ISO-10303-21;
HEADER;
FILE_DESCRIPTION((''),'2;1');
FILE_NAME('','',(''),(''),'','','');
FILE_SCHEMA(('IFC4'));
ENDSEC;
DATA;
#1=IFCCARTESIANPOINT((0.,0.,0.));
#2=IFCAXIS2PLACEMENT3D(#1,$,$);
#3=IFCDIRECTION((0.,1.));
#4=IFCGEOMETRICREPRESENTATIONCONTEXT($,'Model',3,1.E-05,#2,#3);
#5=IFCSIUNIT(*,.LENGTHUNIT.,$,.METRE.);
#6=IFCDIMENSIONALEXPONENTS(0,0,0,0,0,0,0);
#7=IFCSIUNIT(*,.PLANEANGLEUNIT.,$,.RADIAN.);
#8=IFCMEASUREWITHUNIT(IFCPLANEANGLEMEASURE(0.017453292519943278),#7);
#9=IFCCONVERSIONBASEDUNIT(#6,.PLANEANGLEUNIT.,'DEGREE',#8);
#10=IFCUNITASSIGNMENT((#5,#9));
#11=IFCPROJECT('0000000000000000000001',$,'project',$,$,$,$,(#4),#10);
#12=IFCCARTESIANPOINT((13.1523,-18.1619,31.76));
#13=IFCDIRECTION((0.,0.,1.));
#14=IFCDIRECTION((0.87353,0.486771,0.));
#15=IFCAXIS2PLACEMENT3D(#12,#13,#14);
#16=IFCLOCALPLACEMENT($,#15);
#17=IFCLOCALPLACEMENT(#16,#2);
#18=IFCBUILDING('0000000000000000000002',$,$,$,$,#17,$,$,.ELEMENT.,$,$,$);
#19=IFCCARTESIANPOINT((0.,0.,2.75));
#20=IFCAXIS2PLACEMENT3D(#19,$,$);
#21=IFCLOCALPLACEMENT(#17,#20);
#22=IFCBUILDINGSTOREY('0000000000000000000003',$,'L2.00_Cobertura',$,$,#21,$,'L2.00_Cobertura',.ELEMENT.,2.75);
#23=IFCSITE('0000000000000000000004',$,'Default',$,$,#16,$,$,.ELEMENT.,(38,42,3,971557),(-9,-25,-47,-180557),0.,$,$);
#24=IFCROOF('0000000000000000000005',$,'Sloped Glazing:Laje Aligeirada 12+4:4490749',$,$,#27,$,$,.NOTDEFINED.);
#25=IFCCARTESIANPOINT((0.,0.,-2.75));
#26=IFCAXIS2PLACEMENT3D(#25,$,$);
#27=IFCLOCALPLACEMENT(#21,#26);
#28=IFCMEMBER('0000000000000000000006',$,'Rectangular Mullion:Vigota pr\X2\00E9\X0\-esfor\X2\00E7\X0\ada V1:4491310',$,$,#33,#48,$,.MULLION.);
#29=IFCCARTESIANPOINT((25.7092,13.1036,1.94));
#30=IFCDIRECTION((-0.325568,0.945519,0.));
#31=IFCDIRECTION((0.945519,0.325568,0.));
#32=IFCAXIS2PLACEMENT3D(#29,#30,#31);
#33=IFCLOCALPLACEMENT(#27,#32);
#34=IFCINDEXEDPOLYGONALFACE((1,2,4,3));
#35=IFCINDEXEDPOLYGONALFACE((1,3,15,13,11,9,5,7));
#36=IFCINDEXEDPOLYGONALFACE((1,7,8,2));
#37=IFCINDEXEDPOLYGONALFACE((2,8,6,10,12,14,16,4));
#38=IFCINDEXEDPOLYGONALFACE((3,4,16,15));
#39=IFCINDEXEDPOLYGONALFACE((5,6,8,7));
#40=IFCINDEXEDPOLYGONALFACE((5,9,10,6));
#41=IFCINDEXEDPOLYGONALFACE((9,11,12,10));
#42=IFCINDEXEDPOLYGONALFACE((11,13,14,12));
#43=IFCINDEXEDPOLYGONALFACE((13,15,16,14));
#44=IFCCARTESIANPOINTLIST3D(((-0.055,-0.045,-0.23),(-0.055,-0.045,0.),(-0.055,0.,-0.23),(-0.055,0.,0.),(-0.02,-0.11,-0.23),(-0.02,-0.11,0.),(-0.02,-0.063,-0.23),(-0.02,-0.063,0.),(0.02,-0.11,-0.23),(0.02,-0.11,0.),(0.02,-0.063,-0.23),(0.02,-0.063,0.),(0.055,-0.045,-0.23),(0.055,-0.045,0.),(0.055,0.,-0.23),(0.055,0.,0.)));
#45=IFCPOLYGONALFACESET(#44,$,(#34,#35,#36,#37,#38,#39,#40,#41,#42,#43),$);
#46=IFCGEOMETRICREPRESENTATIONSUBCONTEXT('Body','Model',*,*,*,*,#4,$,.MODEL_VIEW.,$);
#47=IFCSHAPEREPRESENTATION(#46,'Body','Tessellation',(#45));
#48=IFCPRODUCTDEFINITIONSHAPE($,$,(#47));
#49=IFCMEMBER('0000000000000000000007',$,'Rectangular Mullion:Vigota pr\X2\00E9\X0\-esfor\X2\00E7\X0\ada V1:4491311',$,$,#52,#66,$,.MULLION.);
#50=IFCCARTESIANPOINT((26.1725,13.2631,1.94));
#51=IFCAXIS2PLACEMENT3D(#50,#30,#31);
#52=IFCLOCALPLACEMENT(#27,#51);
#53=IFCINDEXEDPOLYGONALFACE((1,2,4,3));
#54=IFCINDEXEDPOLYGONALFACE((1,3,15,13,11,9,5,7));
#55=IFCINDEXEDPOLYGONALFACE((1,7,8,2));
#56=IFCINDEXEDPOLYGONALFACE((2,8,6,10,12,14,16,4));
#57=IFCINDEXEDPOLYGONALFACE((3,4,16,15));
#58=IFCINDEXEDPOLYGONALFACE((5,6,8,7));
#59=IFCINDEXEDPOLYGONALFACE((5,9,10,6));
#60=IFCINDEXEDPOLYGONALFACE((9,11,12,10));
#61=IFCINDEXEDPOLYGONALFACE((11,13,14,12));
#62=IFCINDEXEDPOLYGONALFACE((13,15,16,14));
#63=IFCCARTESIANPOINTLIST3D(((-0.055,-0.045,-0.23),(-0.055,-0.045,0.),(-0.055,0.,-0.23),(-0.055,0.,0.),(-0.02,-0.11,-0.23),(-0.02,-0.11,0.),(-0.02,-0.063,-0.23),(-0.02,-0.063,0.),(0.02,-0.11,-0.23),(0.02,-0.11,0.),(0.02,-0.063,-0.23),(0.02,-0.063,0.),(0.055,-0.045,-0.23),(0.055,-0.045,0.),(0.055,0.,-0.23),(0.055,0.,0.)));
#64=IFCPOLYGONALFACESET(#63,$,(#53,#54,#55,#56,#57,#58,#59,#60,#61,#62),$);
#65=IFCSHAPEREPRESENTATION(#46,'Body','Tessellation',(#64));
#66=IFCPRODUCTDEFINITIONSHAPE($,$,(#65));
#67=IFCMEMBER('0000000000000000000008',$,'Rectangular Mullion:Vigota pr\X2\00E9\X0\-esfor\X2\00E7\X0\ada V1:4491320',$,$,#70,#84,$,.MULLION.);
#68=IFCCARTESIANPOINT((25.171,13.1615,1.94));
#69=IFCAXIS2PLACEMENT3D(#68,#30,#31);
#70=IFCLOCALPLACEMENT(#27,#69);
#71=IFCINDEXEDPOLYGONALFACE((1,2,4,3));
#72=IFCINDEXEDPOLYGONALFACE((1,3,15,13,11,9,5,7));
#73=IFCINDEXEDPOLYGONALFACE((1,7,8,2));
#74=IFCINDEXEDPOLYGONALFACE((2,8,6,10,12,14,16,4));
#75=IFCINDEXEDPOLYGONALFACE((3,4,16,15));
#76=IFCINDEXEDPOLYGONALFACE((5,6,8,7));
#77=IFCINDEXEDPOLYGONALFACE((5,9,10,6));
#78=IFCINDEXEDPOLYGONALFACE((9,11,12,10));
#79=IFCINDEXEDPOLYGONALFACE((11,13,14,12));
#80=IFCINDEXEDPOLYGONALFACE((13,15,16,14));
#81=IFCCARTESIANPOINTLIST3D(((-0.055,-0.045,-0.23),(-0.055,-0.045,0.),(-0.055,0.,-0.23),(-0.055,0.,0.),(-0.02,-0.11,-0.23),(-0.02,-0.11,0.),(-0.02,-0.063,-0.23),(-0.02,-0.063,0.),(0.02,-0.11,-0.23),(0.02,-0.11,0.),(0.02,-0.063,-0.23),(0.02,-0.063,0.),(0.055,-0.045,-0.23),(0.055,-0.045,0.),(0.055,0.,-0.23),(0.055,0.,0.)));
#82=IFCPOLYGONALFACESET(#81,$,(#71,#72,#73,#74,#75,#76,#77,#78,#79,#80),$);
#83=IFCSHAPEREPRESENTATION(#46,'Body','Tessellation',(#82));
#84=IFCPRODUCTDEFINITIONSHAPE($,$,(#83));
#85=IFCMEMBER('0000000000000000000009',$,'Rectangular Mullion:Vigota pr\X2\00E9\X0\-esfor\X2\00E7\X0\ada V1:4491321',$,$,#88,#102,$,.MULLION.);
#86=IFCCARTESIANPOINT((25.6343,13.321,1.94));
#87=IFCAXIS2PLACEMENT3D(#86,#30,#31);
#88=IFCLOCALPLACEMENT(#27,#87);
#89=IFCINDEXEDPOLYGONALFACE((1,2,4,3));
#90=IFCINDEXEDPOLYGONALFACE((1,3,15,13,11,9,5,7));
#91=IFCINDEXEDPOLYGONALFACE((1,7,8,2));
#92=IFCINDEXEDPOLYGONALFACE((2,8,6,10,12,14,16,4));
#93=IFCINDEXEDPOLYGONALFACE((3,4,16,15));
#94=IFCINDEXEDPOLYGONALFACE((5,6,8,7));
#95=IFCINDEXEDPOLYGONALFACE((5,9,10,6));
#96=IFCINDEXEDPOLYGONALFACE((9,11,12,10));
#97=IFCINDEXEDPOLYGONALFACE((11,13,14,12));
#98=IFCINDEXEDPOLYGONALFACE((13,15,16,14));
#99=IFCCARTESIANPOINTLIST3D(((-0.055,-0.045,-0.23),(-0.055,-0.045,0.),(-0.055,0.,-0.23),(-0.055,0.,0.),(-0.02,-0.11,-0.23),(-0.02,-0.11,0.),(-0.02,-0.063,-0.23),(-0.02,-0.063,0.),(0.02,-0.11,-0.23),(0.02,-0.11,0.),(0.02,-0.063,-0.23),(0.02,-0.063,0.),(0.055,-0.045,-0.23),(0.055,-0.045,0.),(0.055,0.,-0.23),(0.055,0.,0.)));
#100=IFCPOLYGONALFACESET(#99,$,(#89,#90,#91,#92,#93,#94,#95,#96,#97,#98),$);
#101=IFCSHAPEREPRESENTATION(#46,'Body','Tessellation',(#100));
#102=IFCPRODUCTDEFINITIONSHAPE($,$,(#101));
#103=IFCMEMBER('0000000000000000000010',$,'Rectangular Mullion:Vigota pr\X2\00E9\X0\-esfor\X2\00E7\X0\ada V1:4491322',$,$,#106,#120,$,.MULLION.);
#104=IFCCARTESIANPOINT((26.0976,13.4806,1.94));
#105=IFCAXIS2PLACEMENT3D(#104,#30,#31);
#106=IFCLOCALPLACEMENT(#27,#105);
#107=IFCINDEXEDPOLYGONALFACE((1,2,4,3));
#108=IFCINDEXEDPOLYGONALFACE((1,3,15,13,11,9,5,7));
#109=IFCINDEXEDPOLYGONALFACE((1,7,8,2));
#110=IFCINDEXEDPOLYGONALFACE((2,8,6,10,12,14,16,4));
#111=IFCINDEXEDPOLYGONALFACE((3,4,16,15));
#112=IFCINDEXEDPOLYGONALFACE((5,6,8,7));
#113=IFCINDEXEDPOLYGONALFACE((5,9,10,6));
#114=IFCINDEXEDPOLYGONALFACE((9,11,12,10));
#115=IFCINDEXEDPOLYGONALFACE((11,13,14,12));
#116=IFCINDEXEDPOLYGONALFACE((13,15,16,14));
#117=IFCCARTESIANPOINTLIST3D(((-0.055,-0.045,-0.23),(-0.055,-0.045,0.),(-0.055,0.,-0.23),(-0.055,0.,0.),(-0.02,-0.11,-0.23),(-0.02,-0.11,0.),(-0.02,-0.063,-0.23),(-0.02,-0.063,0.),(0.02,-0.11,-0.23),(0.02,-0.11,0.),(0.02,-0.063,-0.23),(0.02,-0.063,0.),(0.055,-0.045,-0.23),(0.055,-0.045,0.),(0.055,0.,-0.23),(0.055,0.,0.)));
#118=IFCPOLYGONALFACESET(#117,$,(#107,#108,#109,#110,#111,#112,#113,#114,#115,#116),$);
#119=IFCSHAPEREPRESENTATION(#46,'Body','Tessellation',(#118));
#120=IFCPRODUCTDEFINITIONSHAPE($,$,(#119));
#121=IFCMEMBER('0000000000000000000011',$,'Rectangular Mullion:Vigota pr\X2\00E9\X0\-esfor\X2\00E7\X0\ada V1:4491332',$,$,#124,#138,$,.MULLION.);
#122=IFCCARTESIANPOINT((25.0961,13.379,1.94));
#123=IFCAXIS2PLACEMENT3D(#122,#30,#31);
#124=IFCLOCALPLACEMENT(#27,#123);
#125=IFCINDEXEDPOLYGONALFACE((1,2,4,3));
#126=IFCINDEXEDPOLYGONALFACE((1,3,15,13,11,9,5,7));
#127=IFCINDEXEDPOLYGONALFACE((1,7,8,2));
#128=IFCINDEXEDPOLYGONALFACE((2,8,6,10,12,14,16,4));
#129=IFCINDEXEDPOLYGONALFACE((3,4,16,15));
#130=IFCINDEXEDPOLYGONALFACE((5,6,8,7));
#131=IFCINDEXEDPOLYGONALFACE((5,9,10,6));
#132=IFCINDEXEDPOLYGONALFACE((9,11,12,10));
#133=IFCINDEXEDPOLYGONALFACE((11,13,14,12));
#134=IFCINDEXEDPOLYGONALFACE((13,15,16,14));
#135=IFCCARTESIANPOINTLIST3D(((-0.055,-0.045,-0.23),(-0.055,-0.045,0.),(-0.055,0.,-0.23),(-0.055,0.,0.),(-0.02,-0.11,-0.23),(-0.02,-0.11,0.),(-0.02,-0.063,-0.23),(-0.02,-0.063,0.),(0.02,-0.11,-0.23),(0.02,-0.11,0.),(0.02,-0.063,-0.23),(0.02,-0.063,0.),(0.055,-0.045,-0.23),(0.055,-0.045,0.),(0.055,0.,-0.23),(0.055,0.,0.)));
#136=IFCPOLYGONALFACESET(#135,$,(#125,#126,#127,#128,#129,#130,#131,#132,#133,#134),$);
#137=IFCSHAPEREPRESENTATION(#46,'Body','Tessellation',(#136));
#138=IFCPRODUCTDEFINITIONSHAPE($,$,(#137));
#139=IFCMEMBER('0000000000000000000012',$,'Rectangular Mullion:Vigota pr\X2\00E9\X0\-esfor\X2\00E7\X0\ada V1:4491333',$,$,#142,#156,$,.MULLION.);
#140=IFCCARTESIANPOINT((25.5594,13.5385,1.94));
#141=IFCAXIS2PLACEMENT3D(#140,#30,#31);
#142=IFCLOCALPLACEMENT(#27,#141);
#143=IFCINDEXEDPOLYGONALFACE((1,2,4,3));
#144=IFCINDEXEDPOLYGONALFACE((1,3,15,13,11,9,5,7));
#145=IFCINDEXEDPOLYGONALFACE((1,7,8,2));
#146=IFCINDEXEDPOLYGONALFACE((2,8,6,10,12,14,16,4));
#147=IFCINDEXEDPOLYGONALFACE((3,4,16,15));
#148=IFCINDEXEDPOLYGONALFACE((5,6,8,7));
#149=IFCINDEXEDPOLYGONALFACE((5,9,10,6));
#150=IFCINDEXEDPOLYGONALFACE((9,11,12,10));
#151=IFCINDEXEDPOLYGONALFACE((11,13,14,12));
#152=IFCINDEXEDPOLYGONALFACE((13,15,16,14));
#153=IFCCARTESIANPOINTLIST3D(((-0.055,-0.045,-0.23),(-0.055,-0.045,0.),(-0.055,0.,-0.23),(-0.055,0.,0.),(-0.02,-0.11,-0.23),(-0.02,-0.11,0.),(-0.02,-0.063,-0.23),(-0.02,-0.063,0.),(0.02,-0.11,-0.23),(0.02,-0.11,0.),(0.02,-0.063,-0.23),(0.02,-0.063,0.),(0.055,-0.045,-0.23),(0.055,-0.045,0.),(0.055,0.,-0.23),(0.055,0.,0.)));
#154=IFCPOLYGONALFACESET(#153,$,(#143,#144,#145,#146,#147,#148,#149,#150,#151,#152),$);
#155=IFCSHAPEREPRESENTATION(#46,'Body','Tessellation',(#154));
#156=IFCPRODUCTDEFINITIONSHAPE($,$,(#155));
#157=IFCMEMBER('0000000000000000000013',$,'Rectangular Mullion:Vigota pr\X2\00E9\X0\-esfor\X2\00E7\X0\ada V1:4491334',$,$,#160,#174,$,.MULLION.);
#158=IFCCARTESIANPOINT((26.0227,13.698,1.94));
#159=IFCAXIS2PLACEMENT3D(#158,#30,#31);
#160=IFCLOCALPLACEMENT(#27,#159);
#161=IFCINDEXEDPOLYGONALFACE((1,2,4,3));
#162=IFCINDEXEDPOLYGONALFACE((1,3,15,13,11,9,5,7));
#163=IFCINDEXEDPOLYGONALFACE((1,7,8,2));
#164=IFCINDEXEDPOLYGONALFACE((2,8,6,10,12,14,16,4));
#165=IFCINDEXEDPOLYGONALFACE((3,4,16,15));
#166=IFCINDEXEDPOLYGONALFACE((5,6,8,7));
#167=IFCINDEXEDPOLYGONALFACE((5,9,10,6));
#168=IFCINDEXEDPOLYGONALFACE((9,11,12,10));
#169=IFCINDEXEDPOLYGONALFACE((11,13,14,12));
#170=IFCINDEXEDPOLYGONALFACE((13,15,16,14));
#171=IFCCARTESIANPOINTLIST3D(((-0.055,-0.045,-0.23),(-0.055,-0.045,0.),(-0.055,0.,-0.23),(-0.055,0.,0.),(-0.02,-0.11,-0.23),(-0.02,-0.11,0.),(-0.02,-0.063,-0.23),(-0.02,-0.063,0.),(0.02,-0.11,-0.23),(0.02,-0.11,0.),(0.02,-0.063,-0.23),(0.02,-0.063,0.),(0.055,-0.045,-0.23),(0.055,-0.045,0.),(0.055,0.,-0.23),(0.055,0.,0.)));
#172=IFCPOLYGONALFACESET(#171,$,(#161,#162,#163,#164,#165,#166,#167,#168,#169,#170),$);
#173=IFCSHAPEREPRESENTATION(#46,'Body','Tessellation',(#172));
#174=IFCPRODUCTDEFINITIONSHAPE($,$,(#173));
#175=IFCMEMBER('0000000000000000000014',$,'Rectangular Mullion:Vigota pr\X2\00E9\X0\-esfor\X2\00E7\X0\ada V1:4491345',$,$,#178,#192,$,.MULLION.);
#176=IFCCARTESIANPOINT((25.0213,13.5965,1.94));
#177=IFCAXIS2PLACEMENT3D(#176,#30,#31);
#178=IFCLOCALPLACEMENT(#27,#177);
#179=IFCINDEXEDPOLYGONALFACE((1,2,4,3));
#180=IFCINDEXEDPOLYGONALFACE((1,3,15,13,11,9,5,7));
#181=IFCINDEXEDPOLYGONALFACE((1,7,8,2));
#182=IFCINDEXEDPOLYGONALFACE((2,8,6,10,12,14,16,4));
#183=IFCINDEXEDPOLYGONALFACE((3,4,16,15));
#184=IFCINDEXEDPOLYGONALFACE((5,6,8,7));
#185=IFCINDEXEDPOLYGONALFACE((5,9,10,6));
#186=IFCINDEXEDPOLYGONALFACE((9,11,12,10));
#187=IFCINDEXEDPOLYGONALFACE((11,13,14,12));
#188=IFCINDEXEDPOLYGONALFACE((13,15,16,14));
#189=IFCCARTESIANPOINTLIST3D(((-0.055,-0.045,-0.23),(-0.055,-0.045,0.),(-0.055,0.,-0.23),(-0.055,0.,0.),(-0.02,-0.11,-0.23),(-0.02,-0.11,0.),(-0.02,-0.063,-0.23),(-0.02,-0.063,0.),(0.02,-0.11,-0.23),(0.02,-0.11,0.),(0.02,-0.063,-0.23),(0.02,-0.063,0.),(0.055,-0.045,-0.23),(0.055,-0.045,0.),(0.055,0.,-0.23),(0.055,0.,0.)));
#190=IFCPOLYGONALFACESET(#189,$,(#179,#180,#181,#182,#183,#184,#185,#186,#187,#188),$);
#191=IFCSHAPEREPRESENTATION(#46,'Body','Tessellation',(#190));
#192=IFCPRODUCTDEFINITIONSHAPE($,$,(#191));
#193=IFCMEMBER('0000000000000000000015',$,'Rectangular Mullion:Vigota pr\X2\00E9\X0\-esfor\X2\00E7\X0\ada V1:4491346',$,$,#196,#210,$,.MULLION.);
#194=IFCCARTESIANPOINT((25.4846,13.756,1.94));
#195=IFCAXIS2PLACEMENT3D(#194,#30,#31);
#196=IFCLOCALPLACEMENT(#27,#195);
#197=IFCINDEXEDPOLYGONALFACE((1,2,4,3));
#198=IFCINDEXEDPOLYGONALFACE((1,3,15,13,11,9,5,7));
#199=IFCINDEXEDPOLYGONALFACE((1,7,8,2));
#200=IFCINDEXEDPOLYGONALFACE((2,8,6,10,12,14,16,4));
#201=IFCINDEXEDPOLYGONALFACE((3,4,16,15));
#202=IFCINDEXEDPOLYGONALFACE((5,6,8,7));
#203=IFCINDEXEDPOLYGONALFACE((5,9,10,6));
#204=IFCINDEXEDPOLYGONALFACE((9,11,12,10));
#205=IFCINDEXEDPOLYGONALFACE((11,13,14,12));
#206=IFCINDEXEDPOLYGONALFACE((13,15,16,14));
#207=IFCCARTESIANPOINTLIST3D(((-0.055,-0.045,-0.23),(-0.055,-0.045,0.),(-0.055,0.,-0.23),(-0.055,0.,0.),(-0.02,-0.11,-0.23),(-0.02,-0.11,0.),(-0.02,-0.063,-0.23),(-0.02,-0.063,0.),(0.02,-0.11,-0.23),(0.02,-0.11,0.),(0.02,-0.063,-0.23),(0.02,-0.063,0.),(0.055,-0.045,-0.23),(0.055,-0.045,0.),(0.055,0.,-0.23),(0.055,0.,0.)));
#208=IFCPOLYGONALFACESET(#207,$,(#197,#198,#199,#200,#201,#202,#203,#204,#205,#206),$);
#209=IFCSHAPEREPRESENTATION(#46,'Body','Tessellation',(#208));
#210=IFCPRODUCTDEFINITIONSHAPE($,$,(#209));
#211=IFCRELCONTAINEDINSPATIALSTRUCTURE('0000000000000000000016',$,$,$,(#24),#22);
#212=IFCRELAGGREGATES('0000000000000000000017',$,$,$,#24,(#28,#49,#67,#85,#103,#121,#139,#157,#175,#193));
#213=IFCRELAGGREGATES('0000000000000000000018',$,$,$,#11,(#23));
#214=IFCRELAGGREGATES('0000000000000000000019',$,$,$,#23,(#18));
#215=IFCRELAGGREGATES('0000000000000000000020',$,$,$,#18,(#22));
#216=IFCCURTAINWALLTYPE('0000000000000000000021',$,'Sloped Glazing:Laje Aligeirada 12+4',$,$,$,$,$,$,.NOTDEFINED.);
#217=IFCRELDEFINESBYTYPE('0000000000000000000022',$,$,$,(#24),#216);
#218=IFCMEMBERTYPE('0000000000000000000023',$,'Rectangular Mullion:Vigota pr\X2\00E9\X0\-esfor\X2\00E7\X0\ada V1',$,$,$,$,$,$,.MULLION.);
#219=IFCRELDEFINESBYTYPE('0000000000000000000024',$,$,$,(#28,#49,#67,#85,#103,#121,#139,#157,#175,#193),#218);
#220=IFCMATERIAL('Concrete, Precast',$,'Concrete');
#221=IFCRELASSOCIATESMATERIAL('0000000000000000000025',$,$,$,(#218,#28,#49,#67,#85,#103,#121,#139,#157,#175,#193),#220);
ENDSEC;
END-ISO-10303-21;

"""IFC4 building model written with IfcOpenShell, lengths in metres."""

from ifc_helpers import new_model, entity, si_unit, converted_unit, direction, frame, origin, place, context, subcontext, project, spatial, indexed_curve, outline, extrude, source, transform, mapped, material, type_object, type_shapes, element, aggregate, save


model = new_model("IFC4")

# Units and contexts
model_context = context("Model", 3, precision=1e-05, world=origin(), true_north=direction((0.0, 1.0)))
body_context = subcontext(model_context, "Body", "Model", "MODEL_VIEW")
ifc_project = project(units=[si_unit("LENGTHUNIT", "METRE"), converted_unit("PLANEANGLEUNIT", "DEGREE", entity("IfcPlaneAngleMeasure", 0.017453292519943278), si_unit("PLANEANGLEUNIT", "RADIAN"), dimensions=[0, 0, 0, 0, 0, 0, 0])], contexts=[model_context])

# Site, building, storey
site_placement = place(None, frame((13.1523, -18.1619, 31.76), z_axis=(0.0, 0.0, 1.0), x_axis=(0.87353, 0.486771, 0.0)))
site = spatial("IfcSite", under=ifc_project, at=site_placement, Name="Default", CompositionType="ELEMENT", RefLatitude=(38, 42, 3, 971557), RefLongitude=(-9, -25, -47, -180557), RefElevation=0.0)
building_placement = place(site_placement, origin())
building = spatial("IfcBuilding", under=site, at=building_placement, CompositionType="ELEMENT")
storey_placement = place(building_placement, frame((0.0, 0.0, 2.75)))
storey = spatial("IfcBuildingStorey", under=building, at=storey_placement, Name="L2.00_Cobertura", LongName="L2.00_Cobertura", CompositionType="ELEMENT", Elevation=2.75)

# Roof, members
curtain_wall_type = type_object("IfcCurtainWallType", Name="Sloped Glazing:Laje Aligeirada 12+4", PredefinedType="NOTDEFINED")
roof_placement = place(storey_placement, frame((0.0, 0.0, -2.75)))
roof = element("IfcRoof", 1, at=roof_placement, inside=storey, type_object=curtain_wall_type, Name="Sloped Glazing:Laje Aligeirada 12+4:4490749", PredefinedType="NOTDEFINED")
ifc_material_1 = material(Name="Concrete, Precast", Category="Concrete")
member_type = type_object("IfcMemberType", Name="Rectangular Mullion:Vigota pré-esforçada V1", PredefinedType="MULLION", material=ifc_material_1)
shared_shape_1 = source(origin(), body_context, "Body", "SweptSolid", [
    extrude(outline(indexed_curve([(-0.055, -0.0545), (0.055, -0.0545), (0.055, -0.0095), (0.02, 0.0085), (0.02, 0.0555), (-0.02, 0.0555), (-0.02, 0.0085), (-0.055, -0.0095), (-0.055, -0.0545)], self_intersect=False)), frame((0.0, -0.0545, -0.23), z_axis=(0.0, 0.0, 1.0), x_axis=(-1.0, 0.0, 0.0)), (0.0, 0.0, 1.0), 0.23),
])
type_shapes(member_type, [shared_shape_1])
member_1_placement = place(roof_placement, frame((25.7092, 13.1036, 1.94), z_axis=(-0.325568, 0.945519, 0.0), x_axis=(0.945519, 0.325568, 0.0)))
member_1 = element("IfcMember", 2, at=member_1_placement, type_object=member_type, material=ifc_material_1, Name="Rectangular Mullion:Vigota pré-esforçada V1:4491310", PredefinedType="MULLION", context=body_context, shape_type="MappedRepresentation", body=[
    mapped(shared_shape_1, transform((0.0, 0.0, 0.0), scale=1.0)),
])
member_2_placement = place(roof_placement, frame((26.1725, 13.2631, 1.94), z_axis=(-0.325568, 0.945519, 0.0), x_axis=(0.945519, 0.325568, 0.0)))
member_2 = element("IfcMember", 3, at=member_2_placement, type_object=member_type, material=ifc_material_1, Name="Rectangular Mullion:Vigota pré-esforçada V1:4491311", PredefinedType="MULLION", context=body_context, shape_type="MappedRepresentation", body=[
    mapped(shared_shape_1, transform((0.0, 0.0, 0.0), scale=1.0)),
])
member_3_placement = place(roof_placement, frame((25.171, 13.1615, 1.94), z_axis=(-0.325568, 0.945519, 0.0), x_axis=(0.945519, 0.325568, 0.0)))
member_3 = element("IfcMember", 4, at=member_3_placement, type_object=member_type, material=ifc_material_1, Name="Rectangular Mullion:Vigota pré-esforçada V1:4491320", PredefinedType="MULLION", context=body_context, shape_type="MappedRepresentation", body=[
    mapped(shared_shape_1, transform((0.0, 0.0, 0.0), scale=1.0)),
])
member_4_placement = place(roof_placement, frame((25.6343, 13.321, 1.94), z_axis=(-0.325568, 0.945519, 0.0), x_axis=(0.945519, 0.325568, 0.0)))
member_4 = element("IfcMember", 5, at=member_4_placement, type_object=member_type, material=ifc_material_1, Name="Rectangular Mullion:Vigota pré-esforçada V1:4491321", PredefinedType="MULLION", context=body_context, shape_type="MappedRepresentation", body=[
    mapped(shared_shape_1, transform((0.0, 0.0, 0.0), scale=1.0)),
])
member_5_placement = place(roof_placement, frame((26.0976, 13.4806, 1.94), z_axis=(-0.325568, 0.945519, 0.0), x_axis=(0.945519, 0.325568, 0.0)))
member_5 = element("IfcMember", 6, at=member_5_placement, type_object=member_type, material=ifc_material_1, Name="Rectangular Mullion:Vigota pré-esforçada V1:4491322", PredefinedType="MULLION", context=body_context, shape_type="MappedRepresentation", body=[
    mapped(shared_shape_1, transform((0.0, 0.0, 0.0), scale=1.0)),
])
member_6_placement = place(roof_placement, frame((25.0961, 13.379, 1.94), z_axis=(-0.325568, 0.945519, 0.0), x_axis=(0.945519, 0.325568, 0.0)))
member_6 = element("IfcMember", 7, at=member_6_placement, type_object=member_type, material=ifc_material_1, Name="Rectangular Mullion:Vigota pré-esforçada V1:4491332", PredefinedType="MULLION", context=body_context, shape_type="MappedRepresentation", body=[
    mapped(shared_shape_1, transform((0.0, 0.0, 0.0), scale=1.0)),
])
member_7_placement = place(roof_placement, frame((25.5594, 13.5385, 1.94), z_axis=(-0.325568, 0.945519, 0.0), x_axis=(0.945519, 0.325568, 0.0)))
member_7 = element("IfcMember", 8, at=member_7_placement, type_object=member_type, material=ifc_material_1, Name="Rectangular Mullion:Vigota pré-esforçada V1:4491333", PredefinedType="MULLION", context=body_context, shape_type="MappedRepresentation", body=[
    mapped(shared_shape_1, transform((0.0, 0.0, 0.0), scale=1.0)),
])
member_8_placement = place(roof_placement, frame((26.0227, 13.698, 1.94), z_axis=(-0.325568, 0.945519, 0.0), x_axis=(0.945519, 0.325568, 0.0)))
member_8 = element("IfcMember", 9, at=member_8_placement, type_object=member_type, material=ifc_material_1, Name="Rectangular Mullion:Vigota pré-esforçada V1:4491334", PredefinedType="MULLION", context=body_context, shape_type="MappedRepresentation", body=[
    mapped(shared_shape_1, transform((0.0, 0.0, 0.0), scale=1.0)),
])
member_9_placement = place(roof_placement, frame((25.0213, 13.5965, 1.94), z_axis=(-0.325568, 0.945519, 0.0), x_axis=(0.945519, 0.325568, 0.0)))
member_9 = element("IfcMember", 10, at=member_9_placement, type_object=member_type, material=ifc_material_1, Name="Rectangular Mullion:Vigota pré-esforçada V1:4491345", PredefinedType="MULLION", context=body_context, shape_type="MappedRepresentation", body=[
    mapped(shared_shape_1, transform((0.0, 0.0, 0.0), scale=1.0)),
])
member_10_placement = place(roof_placement, frame((25.4846, 13.756, 1.94), z_axis=(-0.325568, 0.945519, 0.0), x_axis=(0.945519, 0.325568, 0.0)))
member_10 = element("IfcMember", 11, at=member_10_placement, type_object=member_type, material=ifc_material_1, Name="Rectangular Mullion:Vigota pré-esforçada V1:4491346", PredefinedType="MULLION", context=body_context, shape_type="MappedRepresentation", body=[
    mapped(shared_shape_1, transform((0.0, 0.0, 0.0), scale=1.0)),
])
aggregate(roof, [member_1, member_2, member_3, member_4, member_5, member_6, member_7, member_8, member_9, member_10])

save(model, "model.ifc")
